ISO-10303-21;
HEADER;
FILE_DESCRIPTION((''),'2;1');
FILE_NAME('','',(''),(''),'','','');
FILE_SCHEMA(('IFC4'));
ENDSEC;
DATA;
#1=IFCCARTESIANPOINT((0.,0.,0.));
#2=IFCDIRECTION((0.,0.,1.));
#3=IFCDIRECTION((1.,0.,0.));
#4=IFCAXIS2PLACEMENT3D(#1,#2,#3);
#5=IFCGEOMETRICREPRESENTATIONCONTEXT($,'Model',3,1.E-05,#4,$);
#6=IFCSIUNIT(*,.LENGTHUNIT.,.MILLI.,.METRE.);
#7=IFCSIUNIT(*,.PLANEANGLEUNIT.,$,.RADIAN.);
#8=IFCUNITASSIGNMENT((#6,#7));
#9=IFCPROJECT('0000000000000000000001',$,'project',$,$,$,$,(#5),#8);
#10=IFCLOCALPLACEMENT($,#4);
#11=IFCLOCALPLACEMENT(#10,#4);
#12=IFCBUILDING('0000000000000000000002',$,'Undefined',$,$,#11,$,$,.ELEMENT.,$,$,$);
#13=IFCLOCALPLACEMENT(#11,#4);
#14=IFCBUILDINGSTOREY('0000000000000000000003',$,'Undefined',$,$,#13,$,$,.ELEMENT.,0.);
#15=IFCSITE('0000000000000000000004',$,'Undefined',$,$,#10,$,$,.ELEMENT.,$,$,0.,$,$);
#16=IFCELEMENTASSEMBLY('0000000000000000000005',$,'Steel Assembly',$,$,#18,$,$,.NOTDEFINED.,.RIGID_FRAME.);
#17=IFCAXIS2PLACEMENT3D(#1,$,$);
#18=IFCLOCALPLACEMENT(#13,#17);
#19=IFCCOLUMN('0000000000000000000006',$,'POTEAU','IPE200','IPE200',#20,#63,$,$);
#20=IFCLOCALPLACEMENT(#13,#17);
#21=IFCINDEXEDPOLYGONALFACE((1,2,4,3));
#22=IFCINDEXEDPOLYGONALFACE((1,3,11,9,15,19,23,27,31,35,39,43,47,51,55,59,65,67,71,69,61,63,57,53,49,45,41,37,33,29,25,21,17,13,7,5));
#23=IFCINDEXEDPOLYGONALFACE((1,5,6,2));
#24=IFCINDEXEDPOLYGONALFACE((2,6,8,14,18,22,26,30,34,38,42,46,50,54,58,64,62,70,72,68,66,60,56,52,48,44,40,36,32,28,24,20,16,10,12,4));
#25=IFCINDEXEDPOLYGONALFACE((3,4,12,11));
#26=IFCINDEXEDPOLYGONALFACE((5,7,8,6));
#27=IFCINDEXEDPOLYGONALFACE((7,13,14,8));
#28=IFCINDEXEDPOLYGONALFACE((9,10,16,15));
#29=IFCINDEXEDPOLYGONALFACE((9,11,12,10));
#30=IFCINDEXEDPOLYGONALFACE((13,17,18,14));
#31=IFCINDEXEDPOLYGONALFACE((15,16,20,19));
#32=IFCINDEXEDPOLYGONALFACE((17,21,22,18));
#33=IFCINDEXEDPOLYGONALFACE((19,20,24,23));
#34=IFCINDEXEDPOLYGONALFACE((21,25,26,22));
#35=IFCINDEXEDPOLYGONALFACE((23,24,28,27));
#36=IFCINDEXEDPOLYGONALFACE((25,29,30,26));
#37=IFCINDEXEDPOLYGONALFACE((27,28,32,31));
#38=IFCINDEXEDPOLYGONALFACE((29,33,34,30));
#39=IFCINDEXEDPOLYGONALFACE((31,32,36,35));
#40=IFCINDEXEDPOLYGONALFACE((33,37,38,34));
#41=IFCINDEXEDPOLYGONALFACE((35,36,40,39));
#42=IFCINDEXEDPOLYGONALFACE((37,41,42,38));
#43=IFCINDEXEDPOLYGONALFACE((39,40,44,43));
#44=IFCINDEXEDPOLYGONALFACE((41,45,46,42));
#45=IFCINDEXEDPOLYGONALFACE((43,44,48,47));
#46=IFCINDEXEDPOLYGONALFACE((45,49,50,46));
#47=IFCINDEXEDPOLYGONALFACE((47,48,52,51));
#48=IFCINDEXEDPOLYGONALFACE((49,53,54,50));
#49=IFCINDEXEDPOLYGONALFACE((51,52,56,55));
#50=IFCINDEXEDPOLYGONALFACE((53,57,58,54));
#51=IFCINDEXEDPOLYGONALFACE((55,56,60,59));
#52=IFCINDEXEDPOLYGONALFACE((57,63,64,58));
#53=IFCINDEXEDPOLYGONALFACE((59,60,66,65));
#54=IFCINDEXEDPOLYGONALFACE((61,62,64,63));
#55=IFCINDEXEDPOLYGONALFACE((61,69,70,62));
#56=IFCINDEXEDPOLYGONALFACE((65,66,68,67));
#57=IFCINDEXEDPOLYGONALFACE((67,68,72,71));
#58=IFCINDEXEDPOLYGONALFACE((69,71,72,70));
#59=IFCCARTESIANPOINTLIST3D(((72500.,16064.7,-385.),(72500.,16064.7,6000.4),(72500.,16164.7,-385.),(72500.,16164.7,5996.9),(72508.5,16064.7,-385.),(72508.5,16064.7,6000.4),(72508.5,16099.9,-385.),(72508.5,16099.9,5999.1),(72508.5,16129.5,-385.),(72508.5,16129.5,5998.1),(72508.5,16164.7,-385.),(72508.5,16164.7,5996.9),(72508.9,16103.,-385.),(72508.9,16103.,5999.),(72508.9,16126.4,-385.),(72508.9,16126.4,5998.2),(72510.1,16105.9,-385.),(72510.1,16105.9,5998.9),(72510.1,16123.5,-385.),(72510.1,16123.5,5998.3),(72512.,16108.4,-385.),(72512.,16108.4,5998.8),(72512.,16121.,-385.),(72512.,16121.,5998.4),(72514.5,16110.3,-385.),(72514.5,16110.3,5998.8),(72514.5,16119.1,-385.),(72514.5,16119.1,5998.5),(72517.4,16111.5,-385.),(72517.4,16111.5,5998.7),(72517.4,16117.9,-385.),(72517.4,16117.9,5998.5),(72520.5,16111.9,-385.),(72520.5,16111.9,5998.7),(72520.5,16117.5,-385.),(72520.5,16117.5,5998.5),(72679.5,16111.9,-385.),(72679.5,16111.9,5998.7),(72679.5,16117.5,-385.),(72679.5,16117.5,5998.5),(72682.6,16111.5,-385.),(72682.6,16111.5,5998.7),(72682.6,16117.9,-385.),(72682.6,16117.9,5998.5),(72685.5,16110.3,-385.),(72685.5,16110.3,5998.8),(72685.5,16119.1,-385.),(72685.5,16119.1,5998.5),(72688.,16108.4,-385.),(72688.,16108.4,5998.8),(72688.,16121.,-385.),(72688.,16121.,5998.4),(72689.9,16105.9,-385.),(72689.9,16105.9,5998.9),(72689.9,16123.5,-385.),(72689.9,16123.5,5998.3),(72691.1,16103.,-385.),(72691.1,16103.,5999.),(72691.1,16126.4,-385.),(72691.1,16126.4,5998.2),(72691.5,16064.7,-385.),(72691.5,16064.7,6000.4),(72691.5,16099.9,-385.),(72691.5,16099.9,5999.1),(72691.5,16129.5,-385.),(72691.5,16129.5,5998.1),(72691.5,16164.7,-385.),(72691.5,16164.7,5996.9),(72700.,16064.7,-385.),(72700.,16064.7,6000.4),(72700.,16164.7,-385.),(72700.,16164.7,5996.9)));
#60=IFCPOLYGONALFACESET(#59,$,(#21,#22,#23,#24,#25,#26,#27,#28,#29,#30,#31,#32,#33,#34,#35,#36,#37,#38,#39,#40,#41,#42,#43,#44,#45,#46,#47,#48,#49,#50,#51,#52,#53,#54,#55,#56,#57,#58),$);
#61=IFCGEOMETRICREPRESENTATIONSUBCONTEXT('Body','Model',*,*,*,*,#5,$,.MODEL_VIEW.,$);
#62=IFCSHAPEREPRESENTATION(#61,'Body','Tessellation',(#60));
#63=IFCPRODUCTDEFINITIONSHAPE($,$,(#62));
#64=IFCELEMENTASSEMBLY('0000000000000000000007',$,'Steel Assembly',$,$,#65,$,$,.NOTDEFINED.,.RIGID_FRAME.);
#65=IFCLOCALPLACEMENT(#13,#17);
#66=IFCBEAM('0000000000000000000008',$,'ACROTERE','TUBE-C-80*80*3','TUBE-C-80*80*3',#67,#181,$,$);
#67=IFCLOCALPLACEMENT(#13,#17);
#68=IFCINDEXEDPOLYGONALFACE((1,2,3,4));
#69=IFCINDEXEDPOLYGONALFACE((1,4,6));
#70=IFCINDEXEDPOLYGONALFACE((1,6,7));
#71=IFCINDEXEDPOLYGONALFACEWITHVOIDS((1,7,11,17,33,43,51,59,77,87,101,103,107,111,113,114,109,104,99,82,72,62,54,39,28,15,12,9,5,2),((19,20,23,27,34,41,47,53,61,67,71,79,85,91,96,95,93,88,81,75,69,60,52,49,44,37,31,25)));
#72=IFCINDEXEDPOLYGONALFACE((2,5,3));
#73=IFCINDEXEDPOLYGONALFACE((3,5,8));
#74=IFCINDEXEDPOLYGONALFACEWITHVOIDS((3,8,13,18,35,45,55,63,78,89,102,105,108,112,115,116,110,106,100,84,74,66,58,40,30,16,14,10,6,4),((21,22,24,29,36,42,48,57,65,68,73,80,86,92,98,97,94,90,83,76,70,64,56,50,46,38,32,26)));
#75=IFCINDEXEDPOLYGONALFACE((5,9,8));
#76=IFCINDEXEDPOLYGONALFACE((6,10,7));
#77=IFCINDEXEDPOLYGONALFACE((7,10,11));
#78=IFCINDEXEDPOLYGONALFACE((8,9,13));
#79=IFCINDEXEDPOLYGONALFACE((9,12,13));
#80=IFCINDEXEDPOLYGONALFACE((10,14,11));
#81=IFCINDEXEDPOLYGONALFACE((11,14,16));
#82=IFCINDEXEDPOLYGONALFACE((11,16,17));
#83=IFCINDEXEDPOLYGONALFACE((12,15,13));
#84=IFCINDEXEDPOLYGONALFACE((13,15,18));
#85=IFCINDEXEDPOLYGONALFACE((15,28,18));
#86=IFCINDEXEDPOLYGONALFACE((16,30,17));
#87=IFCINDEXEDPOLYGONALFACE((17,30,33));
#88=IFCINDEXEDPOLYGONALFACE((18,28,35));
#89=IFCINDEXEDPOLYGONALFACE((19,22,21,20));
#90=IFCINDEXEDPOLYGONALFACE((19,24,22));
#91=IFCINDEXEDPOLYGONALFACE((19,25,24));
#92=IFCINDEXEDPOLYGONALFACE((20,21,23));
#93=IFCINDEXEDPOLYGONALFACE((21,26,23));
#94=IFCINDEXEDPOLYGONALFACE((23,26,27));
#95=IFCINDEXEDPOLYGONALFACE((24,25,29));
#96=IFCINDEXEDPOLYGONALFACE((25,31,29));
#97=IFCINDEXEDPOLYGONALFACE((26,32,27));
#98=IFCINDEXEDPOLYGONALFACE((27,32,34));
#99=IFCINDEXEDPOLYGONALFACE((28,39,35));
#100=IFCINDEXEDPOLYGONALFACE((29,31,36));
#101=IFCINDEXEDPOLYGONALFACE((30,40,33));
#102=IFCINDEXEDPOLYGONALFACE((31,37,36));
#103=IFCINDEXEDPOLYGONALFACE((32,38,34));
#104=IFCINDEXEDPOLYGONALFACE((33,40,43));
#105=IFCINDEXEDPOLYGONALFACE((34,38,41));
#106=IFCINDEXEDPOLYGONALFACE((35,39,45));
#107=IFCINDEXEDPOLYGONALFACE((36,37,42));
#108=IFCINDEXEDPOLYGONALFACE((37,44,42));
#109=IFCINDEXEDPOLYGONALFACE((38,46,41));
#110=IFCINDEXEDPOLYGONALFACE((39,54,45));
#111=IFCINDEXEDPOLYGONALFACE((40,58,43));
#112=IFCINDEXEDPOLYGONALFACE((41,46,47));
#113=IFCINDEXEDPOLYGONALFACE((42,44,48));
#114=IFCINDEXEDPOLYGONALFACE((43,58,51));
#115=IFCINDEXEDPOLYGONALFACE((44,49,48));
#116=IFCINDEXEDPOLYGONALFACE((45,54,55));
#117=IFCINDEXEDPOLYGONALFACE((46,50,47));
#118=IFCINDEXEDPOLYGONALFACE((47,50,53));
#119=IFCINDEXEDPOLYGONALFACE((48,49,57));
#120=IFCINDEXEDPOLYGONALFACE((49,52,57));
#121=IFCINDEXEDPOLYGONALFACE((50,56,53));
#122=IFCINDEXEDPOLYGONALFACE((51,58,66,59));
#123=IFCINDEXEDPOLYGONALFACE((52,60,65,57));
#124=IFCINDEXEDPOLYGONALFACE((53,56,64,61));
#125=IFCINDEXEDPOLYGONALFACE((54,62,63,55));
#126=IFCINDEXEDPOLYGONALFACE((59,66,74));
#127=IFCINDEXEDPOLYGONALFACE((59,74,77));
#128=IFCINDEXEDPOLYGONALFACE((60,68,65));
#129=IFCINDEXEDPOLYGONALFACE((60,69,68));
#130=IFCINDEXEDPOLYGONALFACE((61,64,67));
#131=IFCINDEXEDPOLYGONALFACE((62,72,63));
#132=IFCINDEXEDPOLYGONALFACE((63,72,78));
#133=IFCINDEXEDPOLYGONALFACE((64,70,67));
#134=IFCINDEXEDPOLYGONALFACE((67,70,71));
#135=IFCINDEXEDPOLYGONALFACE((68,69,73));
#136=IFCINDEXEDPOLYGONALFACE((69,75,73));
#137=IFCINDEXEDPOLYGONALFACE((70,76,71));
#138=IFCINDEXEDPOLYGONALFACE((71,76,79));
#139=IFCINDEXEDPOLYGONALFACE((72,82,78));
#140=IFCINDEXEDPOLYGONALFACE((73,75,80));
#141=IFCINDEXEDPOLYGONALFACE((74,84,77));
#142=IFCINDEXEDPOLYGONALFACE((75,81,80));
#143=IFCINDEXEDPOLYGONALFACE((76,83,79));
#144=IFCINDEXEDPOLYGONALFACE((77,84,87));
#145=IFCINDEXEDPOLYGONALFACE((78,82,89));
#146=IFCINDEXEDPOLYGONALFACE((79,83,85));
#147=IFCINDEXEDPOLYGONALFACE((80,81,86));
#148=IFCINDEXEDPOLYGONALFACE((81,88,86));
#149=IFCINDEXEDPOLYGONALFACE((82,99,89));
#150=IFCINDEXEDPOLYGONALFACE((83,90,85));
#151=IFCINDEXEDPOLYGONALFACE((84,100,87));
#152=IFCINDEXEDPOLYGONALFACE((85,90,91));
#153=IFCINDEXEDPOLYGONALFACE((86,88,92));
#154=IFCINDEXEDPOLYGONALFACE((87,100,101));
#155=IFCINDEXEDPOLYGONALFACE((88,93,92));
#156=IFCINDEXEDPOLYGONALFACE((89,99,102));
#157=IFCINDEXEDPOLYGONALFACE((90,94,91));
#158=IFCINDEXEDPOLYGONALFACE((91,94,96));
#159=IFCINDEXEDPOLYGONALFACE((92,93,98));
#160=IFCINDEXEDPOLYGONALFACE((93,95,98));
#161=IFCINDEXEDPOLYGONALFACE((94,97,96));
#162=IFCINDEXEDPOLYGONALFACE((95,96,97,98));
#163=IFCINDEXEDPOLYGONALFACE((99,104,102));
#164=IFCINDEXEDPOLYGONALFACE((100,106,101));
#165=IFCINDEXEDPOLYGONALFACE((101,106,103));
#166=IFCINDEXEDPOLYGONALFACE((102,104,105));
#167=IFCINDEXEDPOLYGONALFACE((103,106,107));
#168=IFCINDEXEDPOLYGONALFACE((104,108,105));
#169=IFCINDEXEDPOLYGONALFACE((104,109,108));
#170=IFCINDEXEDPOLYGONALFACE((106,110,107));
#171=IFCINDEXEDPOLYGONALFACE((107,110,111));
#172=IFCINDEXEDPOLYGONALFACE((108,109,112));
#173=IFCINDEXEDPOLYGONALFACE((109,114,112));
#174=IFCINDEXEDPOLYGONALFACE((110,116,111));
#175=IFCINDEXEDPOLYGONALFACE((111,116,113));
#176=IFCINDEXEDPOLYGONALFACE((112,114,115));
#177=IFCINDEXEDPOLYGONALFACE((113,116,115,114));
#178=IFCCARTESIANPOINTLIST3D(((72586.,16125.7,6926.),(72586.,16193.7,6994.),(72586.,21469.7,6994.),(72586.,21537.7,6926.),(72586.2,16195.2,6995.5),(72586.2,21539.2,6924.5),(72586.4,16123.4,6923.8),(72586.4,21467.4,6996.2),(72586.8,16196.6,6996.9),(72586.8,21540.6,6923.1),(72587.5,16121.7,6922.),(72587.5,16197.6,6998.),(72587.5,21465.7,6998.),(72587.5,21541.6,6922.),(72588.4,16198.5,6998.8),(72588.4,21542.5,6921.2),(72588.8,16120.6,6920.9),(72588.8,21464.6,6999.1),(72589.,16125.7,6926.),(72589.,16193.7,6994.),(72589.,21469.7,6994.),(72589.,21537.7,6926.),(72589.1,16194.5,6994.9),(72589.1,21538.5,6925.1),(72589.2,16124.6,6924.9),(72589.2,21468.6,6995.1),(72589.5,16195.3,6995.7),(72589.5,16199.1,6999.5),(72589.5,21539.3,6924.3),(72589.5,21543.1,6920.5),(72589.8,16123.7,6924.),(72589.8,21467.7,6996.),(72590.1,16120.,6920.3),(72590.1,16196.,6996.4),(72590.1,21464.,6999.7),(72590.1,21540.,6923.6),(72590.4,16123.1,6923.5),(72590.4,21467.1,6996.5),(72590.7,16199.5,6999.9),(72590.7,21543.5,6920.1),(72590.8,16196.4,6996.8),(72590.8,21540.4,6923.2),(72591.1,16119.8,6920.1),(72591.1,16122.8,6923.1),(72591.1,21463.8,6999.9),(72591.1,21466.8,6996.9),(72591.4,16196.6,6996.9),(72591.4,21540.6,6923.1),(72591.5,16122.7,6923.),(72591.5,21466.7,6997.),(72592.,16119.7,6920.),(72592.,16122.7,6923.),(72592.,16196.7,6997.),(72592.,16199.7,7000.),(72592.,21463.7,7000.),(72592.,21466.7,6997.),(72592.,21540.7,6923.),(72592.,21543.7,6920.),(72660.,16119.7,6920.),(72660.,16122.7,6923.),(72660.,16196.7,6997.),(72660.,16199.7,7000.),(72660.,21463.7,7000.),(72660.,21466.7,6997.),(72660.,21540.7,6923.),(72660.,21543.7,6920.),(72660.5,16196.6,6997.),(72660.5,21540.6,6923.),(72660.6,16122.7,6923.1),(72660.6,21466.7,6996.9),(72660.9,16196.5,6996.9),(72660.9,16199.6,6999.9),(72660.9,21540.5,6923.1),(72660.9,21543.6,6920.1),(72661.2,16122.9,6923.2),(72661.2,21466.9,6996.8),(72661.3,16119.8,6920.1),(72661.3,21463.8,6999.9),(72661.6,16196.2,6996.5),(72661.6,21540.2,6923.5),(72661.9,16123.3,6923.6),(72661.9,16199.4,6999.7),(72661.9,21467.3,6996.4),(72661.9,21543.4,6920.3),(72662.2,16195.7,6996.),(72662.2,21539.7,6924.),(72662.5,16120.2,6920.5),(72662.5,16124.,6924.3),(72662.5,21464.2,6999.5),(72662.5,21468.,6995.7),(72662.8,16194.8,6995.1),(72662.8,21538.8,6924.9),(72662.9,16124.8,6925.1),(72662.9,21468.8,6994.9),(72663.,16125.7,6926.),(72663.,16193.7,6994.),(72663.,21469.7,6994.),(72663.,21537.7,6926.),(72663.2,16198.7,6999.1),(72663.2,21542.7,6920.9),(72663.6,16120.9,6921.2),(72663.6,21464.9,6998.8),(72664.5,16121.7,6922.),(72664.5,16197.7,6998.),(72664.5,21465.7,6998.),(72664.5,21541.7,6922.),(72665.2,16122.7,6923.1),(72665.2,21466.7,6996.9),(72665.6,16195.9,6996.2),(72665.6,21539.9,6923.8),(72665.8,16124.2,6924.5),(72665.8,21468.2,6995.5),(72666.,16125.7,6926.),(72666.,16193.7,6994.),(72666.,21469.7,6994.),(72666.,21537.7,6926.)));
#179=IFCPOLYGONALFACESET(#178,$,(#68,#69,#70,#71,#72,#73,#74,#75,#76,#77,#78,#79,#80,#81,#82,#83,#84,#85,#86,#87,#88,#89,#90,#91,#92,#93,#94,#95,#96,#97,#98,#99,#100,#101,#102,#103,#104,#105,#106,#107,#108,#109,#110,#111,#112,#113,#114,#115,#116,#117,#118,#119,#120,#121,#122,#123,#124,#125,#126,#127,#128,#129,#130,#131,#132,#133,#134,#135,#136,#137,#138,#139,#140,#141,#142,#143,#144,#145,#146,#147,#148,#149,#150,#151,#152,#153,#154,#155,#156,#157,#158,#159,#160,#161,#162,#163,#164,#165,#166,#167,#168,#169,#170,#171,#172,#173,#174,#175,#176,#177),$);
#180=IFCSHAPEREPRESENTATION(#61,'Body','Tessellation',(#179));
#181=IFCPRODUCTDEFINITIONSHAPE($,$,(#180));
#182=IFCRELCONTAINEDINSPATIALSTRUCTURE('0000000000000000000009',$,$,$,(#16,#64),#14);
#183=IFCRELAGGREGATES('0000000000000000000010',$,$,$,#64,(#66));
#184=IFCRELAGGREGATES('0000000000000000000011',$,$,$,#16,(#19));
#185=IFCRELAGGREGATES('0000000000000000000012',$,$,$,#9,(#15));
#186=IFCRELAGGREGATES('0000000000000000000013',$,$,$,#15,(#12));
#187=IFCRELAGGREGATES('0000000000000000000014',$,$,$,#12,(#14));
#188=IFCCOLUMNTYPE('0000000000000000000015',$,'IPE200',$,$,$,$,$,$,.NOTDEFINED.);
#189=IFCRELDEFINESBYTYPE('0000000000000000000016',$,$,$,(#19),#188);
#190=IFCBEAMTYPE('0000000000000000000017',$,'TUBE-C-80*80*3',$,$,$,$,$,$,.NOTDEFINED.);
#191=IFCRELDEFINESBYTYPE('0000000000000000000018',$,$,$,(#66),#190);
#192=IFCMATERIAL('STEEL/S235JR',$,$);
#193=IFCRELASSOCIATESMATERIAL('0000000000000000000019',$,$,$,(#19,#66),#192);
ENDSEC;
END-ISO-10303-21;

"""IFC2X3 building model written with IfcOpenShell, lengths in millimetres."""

from ifc_helpers import new_model, si_unit, frame, origin_with_axes, origin_2d_with_axis, place, context, subcontext, project, spatial, hollow_rectangle, i_section, extrude, clip, halfspace, material, type_object, element, aggregate, save


model = new_model("IFC2X3")

# Units and contexts
model_context = context("Model", 3, precision=1e-05, world=origin_with_axes())
body_context = subcontext(model_context, "Body", "Model", "MODEL_VIEW")
ifc_project = project(units=[si_unit("LENGTHUNIT", "METRE", prefix="MILLI"), si_unit("PLANEANGLEUNIT", "RADIAN")], contexts=[model_context])

# Site, building, storey
site_placement = place(None, origin_with_axes())
site = spatial("IfcSite", under=ifc_project, at=site_placement, Name="Undefined", CompositionType="ELEMENT", RefElevation=0.0)
building_placement = place(site_placement, origin_with_axes())
building = spatial("IfcBuilding", under=site, at=building_placement, Name="Undefined", CompositionType="ELEMENT")
storey_placement = place(building_placement, origin_with_axes())
storey = spatial("IfcBuildingStorey", under=building, at=storey_placement, Name="Undefined", CompositionType="ELEMENT", Elevation=0.0)

# Element assembly, column
assembly_1_placement = place(storey_placement, origin_with_axes())
assembly_1 = element("IfcElementAssembly", 1, at=assembly_1_placement, inside=storey, Name="Steel Assembly", AssemblyPlace="NOTDEFINED", PredefinedType="RIGID_FRAME")
ifc_material_1 = material(Name="STEEL/S235JR")
column_type = type_object("IfcColumnType", Name="IPE200", PredefinedType="NOTDEFINED")
column_placement = place(assembly_1_placement, frame((72600.0, 16114.7, -400.0), z_axis=(0.0, 0.0, 1.0), x_axis=(1.0, 0.0, 0.0)))
column = element("IfcColumn", 2, at=column_placement, type_object=column_type, material=ifc_material_1, Name="POTEAU", Description="IPE200", ObjectType="IPE200", context=body_context, shape_type="Clipping", body=[
    clip(clip(extrude(i_section(OverallWidth=100.0, OverallDepth=200.0, WebThickness=5.6, FlangeThickness=8.5, FilletRadius=12.0, at=origin_2d_with_axis()), frame((0.0, 0.0, 6424.9), z_axis=(0.0, 0.0, -1.0), x_axis=(0.0, 1.0, 0.0)), (0.0, 0.0, 1.0), 6409.9), halfspace(frame((-100.0, 50.0, 6396.9), z_axis=(0.0, 0.034979, 0.999388), x_axis=(1.0, 0.0, 0.0)), False)), halfspace(frame((-100.0, 0.0, 15.0), z_axis=(0.0, 0.0, 1.0), x_axis=(0.0, 1.0, 0.0)), True)),
])

# Element assembly, beam
assembly_2_placement = place(storey_placement, origin_with_axes())
assembly_2 = element("IfcElementAssembly", 3, at=assembly_2_placement, inside=storey, Name="Steel Assembly", AssemblyPlace="NOTDEFINED", PredefinedType="RIGID_FRAME")
beam_type_1 = type_object("IfcBeamType", Name="TUBE-C-80*80*3", PredefinedType="NOTDEFINED")
beam_1_placement = place(assembly_2_placement, frame((72626.0, 16114.7, 6960.0), z_axis=(0.0, 0.0, 1.0), x_axis=(0.0, 1.0, 0.0)))
beam_1 = element("IfcBeam", 4, at=beam_1_placement, type_object=beam_type_1, material=ifc_material_1, Name="ACROTERE", Description="TUBE-C-80*80*3", ObjectType="TUBE-C-80*80*3", context=body_context, shape_type="Clipping", body=[
    clip(clip(extrude(hollow_rectangle(XDim=80.0, YDim=80.0, WallThickness=3.0, InnerFilletRadius=3.0, OuterFilletRadius=6.0, at=origin_2d_with_axis()), frame((5434.0, 0.0, 0.0), z_axis=(-1.0, 0.0, 0.0), x_axis=(0.0, -1.0, 0.0)), (0.0, 0.0, 1.0), 5434.0), halfspace(frame((5.0, 40.0, -40.0), z_axis=(-0.707107, 0.0, 0.707107), x_axis=(0.707107, 0.0, 0.707107)), False)), halfspace(frame((5429.0, -40.0, -40.0), z_axis=(0.707107, 0.0, 0.707107), x_axis=(-0.707107, 0.0, 0.707107)), False)),
])
aggregate(assembly_2, [beam_1])

aggregate(assembly_1, [column])

save(model, "model.ifc")
